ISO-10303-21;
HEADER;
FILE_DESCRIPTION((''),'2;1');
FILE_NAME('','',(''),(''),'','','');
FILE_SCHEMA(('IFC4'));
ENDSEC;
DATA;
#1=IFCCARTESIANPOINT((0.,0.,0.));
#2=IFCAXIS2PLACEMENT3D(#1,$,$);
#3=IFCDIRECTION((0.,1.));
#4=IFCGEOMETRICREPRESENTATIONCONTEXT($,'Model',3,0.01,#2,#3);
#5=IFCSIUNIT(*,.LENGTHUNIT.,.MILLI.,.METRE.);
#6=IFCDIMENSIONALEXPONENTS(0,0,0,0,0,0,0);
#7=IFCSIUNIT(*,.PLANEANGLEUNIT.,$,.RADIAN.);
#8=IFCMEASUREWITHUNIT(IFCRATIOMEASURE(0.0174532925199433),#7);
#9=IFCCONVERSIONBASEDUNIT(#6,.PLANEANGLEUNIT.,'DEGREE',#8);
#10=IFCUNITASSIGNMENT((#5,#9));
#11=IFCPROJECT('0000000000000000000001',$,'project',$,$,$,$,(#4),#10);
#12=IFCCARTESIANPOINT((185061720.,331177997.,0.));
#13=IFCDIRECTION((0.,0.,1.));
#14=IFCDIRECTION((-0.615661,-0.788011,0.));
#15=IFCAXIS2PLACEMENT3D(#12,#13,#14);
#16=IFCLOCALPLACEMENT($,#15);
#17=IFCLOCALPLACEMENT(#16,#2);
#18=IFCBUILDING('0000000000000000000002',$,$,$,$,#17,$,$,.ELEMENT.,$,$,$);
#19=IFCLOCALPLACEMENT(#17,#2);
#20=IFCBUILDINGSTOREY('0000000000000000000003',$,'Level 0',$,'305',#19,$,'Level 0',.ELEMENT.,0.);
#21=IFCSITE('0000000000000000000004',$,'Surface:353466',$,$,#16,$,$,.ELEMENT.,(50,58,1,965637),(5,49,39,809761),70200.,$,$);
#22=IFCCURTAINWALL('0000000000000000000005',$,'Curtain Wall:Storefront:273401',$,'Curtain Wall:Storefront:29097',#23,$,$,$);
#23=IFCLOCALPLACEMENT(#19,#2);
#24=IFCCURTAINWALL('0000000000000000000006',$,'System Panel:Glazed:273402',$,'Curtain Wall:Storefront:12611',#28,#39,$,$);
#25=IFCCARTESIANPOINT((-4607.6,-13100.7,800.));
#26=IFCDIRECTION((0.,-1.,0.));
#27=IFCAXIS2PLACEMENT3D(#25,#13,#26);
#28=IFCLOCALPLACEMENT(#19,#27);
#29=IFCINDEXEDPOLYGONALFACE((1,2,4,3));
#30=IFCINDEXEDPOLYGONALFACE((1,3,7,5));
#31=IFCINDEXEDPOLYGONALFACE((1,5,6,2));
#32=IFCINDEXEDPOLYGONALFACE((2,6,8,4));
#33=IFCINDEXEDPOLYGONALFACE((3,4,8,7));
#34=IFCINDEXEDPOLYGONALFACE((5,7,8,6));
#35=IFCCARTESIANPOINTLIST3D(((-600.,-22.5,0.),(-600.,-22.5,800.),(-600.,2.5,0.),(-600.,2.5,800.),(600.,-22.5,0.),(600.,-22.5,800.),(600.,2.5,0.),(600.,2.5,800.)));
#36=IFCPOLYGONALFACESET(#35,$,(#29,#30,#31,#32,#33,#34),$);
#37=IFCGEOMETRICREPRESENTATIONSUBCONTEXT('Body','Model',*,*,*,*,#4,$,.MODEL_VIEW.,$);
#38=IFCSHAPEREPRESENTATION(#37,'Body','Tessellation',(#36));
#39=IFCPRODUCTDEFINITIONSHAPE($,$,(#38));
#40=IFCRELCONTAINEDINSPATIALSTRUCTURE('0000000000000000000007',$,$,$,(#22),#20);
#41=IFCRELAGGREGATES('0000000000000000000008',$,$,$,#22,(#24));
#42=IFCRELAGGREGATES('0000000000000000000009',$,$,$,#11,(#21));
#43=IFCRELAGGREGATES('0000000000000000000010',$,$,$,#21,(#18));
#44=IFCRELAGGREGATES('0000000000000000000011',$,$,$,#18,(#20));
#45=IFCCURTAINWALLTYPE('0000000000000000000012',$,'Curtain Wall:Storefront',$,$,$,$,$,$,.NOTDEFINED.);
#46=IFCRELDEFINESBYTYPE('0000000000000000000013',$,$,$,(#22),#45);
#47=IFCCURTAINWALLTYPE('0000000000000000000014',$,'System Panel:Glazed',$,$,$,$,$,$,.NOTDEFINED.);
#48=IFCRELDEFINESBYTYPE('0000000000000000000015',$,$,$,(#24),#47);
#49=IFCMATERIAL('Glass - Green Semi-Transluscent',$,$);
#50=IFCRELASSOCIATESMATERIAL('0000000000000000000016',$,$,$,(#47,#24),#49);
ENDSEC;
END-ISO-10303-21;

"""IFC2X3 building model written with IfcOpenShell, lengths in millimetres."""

from ifc_helpers import new_model, entity, si_unit, converted_unit, direction, frame, origin, origin_2d_with_axis, place, context, subcontext, project, spatial, rectangle, extrude, source, transform, mapped, material, type_object, type_shapes, element, aggregate, save


model = new_model("IFC2X3")

# Units and contexts
model_context = context("Model", 3, precision=0.01, world=origin(), true_north=direction((0.0, 1.0)))
body_context = subcontext(model_context, "Body", "Model", "MODEL_VIEW")
ifc_project = project(units=[si_unit("LENGTHUNIT", "METRE", prefix="MILLI"), converted_unit("PLANEANGLEUNIT", "DEGREE", entity("IfcRatioMeasure", 0.0174532925199433), si_unit("PLANEANGLEUNIT", "RADIAN"), dimensions=[0, 0, 0, 0, 0, 0, 0])], contexts=[model_context])

# Site, building, storey
site_placement = place(None, frame((185061720.0, 331177997.0, 0.0), z_axis=(0.0, 0.0, 1.0), x_axis=(-0.615661, -0.788011, 0.0)))
site = spatial("IfcSite", under=ifc_project, at=site_placement, Name="Surface:353466", CompositionType="ELEMENT", RefLatitude=(50, 58, 1, 965637), RefLongitude=(5, 49, 39, 809761), RefElevation=70200.0)
building_placement = place(site_placement, origin())
building = spatial("IfcBuilding", under=site, at=building_placement, CompositionType="ELEMENT")
storey_placement = place(building_placement, origin())
storey = spatial("IfcBuildingStorey", under=building, at=storey_placement, Name="Level 0", ObjectType="305", LongName="Level 0", CompositionType="ELEMENT", Elevation=0.0)

# Curtain walls
curtain_wall_type_1 = type_object("IfcCurtainWallType", Name="Curtain Wall:Storefront", PredefinedType="NOTDEFINED")
curtain_wall_1_placement = place(storey_placement, origin())
curtain_wall_1 = element("IfcCurtainWall", 1, at=curtain_wall_1_placement, inside=storey, type_object=curtain_wall_type_1, Name="Curtain Wall:Storefront:273401", ObjectType="Curtain Wall:Storefront:29097")
ifc_material_1 = material(Name="Glass - Green Semi-Transluscent")
curtain_wall_type_2 = type_object("IfcCurtainWallType", Name="System Panel:Glazed", PredefinedType="NOTDEFINED", material=ifc_material_1)
shared_shape_1 = source(origin(), body_context, "Body", "SweptSolid", [
    extrude(rectangle(XDim=25.0, YDim=1200.0, at=origin_2d_with_axis()), frame((0.0, -10.0, 0.0), z_axis=(0.0, 0.0, 1.0), x_axis=(0.0, 1.0, 0.0)), (0.0, 0.0, 1.0), 800.0),
])
type_shapes(curtain_wall_type_2, [shared_shape_1])
curtain_wall_2_placement = place(storey_placement, frame((-4607.6, -13100.7, 800.0), z_axis=(0.0, 0.0, 1.0), x_axis=(0.0, -1.0, 0.0)))
curtain_wall_2 = element("IfcCurtainWall", 2, at=curtain_wall_2_placement, type_object=curtain_wall_type_2, material=ifc_material_1, Name="System Panel:Glazed:273402", ObjectType="Curtain Wall:Storefront:12611", context=body_context, shape_type="MappedRepresentation", body=[
    mapped(shared_shape_1, transform((0.0, 0.0, 0.0), scale=1.0)),
])
aggregate(curtain_wall_1, [curtain_wall_2])

save(model, "model.ifc")
